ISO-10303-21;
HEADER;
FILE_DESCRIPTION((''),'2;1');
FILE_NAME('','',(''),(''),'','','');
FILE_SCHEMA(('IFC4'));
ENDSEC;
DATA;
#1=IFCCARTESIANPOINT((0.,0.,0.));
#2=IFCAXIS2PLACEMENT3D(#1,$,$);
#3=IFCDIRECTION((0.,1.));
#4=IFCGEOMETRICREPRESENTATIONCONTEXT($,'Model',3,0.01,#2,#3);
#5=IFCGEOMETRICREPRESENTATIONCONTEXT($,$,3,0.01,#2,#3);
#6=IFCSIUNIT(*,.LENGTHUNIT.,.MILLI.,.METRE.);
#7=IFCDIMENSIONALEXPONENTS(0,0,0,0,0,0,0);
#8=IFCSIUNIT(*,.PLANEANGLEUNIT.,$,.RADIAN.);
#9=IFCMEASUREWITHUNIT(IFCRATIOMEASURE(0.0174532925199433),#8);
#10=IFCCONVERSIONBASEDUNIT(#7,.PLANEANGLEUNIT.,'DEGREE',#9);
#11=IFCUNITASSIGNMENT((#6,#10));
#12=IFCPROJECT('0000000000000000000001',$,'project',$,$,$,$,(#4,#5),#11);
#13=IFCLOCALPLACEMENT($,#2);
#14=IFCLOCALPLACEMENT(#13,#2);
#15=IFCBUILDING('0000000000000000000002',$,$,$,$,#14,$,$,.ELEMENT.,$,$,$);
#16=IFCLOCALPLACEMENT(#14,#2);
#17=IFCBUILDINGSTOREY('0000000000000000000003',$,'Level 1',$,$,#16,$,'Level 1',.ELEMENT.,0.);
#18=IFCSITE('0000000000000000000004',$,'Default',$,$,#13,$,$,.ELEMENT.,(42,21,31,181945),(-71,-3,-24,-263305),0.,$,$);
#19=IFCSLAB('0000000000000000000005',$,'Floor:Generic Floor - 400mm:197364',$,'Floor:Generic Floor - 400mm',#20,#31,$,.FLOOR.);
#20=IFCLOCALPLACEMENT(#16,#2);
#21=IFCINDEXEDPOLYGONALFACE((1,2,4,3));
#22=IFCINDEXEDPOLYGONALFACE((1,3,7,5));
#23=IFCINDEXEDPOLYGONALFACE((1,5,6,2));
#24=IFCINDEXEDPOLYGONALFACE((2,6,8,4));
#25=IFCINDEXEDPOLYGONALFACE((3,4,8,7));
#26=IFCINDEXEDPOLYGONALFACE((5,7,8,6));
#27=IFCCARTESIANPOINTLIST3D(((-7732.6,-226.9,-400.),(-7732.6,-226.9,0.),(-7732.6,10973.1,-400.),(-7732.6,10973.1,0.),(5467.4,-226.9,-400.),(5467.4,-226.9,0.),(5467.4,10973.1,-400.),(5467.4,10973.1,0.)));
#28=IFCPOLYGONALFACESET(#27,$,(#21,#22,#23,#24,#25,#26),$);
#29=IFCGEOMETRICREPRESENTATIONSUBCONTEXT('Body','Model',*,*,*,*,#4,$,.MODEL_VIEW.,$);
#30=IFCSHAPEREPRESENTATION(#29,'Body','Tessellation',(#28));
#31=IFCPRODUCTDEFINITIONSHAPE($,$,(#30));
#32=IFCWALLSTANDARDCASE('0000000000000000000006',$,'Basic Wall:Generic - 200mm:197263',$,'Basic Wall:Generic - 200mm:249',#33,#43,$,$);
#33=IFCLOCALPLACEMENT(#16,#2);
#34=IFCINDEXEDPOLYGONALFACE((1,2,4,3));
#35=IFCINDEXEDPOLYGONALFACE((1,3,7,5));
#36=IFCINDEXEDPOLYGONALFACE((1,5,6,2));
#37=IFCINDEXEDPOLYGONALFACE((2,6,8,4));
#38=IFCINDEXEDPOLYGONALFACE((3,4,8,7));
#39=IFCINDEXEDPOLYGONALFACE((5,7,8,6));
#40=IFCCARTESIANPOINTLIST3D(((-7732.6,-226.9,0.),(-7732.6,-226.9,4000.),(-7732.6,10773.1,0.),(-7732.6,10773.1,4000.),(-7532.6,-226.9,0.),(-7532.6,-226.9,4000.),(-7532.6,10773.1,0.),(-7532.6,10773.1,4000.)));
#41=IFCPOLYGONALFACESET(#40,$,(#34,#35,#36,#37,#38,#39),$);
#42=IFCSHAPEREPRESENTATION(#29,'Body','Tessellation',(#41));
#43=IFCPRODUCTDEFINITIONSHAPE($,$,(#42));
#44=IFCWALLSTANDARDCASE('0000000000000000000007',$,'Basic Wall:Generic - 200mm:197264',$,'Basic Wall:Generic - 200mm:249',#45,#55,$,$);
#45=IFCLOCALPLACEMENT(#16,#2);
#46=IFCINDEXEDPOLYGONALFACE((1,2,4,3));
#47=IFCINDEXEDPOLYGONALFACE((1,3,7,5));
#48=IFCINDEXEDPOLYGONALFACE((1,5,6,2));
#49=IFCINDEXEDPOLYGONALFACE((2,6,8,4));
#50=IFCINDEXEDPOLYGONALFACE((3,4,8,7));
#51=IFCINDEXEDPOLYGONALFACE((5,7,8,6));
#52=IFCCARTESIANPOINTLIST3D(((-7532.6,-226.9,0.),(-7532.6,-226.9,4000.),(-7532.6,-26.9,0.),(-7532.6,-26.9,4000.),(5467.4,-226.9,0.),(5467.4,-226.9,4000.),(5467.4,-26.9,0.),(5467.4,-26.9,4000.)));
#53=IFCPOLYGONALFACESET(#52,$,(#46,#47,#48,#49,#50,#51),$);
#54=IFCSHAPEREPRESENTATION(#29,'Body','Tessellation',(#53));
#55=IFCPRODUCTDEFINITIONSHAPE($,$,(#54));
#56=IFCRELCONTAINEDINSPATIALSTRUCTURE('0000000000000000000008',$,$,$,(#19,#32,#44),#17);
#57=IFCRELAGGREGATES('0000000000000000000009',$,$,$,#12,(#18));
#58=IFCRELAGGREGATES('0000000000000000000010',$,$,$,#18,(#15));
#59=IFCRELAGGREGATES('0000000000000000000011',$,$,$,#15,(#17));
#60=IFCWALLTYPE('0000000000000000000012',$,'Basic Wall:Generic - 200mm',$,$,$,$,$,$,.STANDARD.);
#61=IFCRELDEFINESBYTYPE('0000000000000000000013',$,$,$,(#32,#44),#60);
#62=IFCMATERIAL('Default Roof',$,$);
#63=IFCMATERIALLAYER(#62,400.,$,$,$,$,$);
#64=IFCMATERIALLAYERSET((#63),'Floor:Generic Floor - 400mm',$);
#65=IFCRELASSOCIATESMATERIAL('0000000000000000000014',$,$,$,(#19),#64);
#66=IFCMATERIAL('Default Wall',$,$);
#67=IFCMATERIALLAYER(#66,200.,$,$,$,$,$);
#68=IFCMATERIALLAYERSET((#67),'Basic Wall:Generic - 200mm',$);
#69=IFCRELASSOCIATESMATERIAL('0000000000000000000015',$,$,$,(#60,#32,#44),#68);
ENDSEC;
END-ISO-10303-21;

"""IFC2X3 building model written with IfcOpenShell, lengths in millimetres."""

from ifc_helpers import new_model, entity, si_unit, converted_unit, direction, frame, frame_2d, origin, place, context, subcontext, project, spatial, rectangle, extrude, material, layer, layer_set, layer_usage, type_object, element, save


model = new_model("IFC2X3")

# Units and contexts
model_context = context("Model", 3, precision=0.01, world=origin(), true_north=direction((0.0, 1.0)))
context_of_model = context(None, 3, precision=0.01, world=origin(), true_north=direction((0.0, 1.0)))
body_context = subcontext(model_context, "Body", "Model", "MODEL_VIEW")
ifc_project = project(units=[si_unit("LENGTHUNIT", "METRE", prefix="MILLI"), converted_unit("PLANEANGLEUNIT", "DEGREE", entity("IfcRatioMeasure", 0.0174532925199433), si_unit("PLANEANGLEUNIT", "RADIAN"), dimensions=[0, 0, 0, 0, 0, 0, 0])], contexts=[model_context, context_of_model])

# Site, building, storey
site_placement = place(None, origin())
site = spatial("IfcSite", under=ifc_project, at=site_placement, Name="Default", CompositionType="ELEMENT", RefLatitude=(42, 21, 31, 181945), RefLongitude=(-71, -3, -24, -263305), RefElevation=0.0)
building_placement = place(site_placement, origin())
building = spatial("IfcBuilding", under=site, at=building_placement, CompositionType="ELEMENT")
storey_placement = place(building_placement, origin())
storey = spatial("IfcBuildingStorey", under=building, at=storey_placement, Name="Level 1", LongName="Level 1", CompositionType="ELEMENT", Elevation=0.0)

# Slab
ifc_material_1 = material(Name="Default Roof")
ifc_layer_1 = layer(ifc_material_1, 400.0)
ifc_layer_set_1 = layer_set([ifc_layer_1], Name="Floor:Generic Floor - 400mm")
ifc_layer_usage_1 = layer_usage(ifc_layer_set_1, "AXIS3", "POSITIVE", 0.0)
slab_placement = place(storey_placement, origin())
element("IfcSlab", 1, at=slab_placement, inside=storey, material=ifc_layer_usage_1, Name="Floor:Generic Floor - 400mm:197364", ObjectType="Floor:Generic Floor - 400mm", PredefinedType="FLOOR", context=body_context, shape_type="SweptSolid", body=[
    extrude(rectangle(XDim=11200.0, YDim=13200.0, at=frame_2d((0.0, 0.0), x_axis=(1.0, 0.0))), frame((-1132.6, 5373.1, 0.0), z_axis=(0.0, 0.0, -1.0), x_axis=(0.0, 1.0, 0.0)), (0.0, 0.0, 1.0), 400.0),
])

# Shared definitions
ifc_material_2 = material(Name="Default Wall")
ifc_layer_2 = layer(ifc_material_2, 200.0)
ifc_layer_set_2 = layer_set([ifc_layer_2], Name="Basic Wall:Generic - 200mm")
wall_type = type_object("IfcWallType", Name="Basic Wall:Generic - 200mm", PredefinedType="STANDARD", material=ifc_layer_set_2)

# Walls
ifc_layer_usage_2 = layer_usage(ifc_layer_set_2, "AXIS2", "NEGATIVE", 100.0)
wall_1_placement = place(storey_placement, frame((-7632.6, -226.9, 0.0), z_axis=(0.0, 0.0, 1.0), x_axis=(0.0, 1.0, 0.0)))
element("IfcWallStandardCase", 2, at=wall_1_placement, inside=storey, type_object=wall_type, material=ifc_layer_usage_2, Name="Basic Wall:Generic - 200mm:197263", ObjectType="Basic Wall:Generic - 200mm:249", context=body_context, shape_type="SweptSolid", body=[
    extrude(rectangle(XDim=11000.0, YDim=200.0, at=frame_2d((5500.0, 0.0), x_axis=(-1.0, 0.0))), origin(), (0.0, 0.0, 1.0), 4000.0),
])
ifc_layer_usage_3 = layer_usage(ifc_layer_set_2, "AXIS2", "NEGATIVE", 100.0)
wall_2_placement = place(storey_placement, frame((5467.4, -126.9, 0.0), z_axis=(0.0, 0.0, 1.0), x_axis=(-1.0, 0.0, 0.0)))
element("IfcWallStandardCase", 3, at=wall_2_placement, inside=storey, type_object=wall_type, material=ifc_layer_usage_3, Name="Basic Wall:Generic - 200mm:197264", ObjectType="Basic Wall:Generic - 200mm:249", context=body_context, shape_type="SweptSolid", body=[
    extrude(rectangle(XDim=13000.0, YDim=200.0, at=frame_2d((6500.0, 0.0), x_axis=(-1.0, 0.0))), origin(), (0.0, 0.0, 1.0), 4000.0),
])

save(model, "model.ifc")
